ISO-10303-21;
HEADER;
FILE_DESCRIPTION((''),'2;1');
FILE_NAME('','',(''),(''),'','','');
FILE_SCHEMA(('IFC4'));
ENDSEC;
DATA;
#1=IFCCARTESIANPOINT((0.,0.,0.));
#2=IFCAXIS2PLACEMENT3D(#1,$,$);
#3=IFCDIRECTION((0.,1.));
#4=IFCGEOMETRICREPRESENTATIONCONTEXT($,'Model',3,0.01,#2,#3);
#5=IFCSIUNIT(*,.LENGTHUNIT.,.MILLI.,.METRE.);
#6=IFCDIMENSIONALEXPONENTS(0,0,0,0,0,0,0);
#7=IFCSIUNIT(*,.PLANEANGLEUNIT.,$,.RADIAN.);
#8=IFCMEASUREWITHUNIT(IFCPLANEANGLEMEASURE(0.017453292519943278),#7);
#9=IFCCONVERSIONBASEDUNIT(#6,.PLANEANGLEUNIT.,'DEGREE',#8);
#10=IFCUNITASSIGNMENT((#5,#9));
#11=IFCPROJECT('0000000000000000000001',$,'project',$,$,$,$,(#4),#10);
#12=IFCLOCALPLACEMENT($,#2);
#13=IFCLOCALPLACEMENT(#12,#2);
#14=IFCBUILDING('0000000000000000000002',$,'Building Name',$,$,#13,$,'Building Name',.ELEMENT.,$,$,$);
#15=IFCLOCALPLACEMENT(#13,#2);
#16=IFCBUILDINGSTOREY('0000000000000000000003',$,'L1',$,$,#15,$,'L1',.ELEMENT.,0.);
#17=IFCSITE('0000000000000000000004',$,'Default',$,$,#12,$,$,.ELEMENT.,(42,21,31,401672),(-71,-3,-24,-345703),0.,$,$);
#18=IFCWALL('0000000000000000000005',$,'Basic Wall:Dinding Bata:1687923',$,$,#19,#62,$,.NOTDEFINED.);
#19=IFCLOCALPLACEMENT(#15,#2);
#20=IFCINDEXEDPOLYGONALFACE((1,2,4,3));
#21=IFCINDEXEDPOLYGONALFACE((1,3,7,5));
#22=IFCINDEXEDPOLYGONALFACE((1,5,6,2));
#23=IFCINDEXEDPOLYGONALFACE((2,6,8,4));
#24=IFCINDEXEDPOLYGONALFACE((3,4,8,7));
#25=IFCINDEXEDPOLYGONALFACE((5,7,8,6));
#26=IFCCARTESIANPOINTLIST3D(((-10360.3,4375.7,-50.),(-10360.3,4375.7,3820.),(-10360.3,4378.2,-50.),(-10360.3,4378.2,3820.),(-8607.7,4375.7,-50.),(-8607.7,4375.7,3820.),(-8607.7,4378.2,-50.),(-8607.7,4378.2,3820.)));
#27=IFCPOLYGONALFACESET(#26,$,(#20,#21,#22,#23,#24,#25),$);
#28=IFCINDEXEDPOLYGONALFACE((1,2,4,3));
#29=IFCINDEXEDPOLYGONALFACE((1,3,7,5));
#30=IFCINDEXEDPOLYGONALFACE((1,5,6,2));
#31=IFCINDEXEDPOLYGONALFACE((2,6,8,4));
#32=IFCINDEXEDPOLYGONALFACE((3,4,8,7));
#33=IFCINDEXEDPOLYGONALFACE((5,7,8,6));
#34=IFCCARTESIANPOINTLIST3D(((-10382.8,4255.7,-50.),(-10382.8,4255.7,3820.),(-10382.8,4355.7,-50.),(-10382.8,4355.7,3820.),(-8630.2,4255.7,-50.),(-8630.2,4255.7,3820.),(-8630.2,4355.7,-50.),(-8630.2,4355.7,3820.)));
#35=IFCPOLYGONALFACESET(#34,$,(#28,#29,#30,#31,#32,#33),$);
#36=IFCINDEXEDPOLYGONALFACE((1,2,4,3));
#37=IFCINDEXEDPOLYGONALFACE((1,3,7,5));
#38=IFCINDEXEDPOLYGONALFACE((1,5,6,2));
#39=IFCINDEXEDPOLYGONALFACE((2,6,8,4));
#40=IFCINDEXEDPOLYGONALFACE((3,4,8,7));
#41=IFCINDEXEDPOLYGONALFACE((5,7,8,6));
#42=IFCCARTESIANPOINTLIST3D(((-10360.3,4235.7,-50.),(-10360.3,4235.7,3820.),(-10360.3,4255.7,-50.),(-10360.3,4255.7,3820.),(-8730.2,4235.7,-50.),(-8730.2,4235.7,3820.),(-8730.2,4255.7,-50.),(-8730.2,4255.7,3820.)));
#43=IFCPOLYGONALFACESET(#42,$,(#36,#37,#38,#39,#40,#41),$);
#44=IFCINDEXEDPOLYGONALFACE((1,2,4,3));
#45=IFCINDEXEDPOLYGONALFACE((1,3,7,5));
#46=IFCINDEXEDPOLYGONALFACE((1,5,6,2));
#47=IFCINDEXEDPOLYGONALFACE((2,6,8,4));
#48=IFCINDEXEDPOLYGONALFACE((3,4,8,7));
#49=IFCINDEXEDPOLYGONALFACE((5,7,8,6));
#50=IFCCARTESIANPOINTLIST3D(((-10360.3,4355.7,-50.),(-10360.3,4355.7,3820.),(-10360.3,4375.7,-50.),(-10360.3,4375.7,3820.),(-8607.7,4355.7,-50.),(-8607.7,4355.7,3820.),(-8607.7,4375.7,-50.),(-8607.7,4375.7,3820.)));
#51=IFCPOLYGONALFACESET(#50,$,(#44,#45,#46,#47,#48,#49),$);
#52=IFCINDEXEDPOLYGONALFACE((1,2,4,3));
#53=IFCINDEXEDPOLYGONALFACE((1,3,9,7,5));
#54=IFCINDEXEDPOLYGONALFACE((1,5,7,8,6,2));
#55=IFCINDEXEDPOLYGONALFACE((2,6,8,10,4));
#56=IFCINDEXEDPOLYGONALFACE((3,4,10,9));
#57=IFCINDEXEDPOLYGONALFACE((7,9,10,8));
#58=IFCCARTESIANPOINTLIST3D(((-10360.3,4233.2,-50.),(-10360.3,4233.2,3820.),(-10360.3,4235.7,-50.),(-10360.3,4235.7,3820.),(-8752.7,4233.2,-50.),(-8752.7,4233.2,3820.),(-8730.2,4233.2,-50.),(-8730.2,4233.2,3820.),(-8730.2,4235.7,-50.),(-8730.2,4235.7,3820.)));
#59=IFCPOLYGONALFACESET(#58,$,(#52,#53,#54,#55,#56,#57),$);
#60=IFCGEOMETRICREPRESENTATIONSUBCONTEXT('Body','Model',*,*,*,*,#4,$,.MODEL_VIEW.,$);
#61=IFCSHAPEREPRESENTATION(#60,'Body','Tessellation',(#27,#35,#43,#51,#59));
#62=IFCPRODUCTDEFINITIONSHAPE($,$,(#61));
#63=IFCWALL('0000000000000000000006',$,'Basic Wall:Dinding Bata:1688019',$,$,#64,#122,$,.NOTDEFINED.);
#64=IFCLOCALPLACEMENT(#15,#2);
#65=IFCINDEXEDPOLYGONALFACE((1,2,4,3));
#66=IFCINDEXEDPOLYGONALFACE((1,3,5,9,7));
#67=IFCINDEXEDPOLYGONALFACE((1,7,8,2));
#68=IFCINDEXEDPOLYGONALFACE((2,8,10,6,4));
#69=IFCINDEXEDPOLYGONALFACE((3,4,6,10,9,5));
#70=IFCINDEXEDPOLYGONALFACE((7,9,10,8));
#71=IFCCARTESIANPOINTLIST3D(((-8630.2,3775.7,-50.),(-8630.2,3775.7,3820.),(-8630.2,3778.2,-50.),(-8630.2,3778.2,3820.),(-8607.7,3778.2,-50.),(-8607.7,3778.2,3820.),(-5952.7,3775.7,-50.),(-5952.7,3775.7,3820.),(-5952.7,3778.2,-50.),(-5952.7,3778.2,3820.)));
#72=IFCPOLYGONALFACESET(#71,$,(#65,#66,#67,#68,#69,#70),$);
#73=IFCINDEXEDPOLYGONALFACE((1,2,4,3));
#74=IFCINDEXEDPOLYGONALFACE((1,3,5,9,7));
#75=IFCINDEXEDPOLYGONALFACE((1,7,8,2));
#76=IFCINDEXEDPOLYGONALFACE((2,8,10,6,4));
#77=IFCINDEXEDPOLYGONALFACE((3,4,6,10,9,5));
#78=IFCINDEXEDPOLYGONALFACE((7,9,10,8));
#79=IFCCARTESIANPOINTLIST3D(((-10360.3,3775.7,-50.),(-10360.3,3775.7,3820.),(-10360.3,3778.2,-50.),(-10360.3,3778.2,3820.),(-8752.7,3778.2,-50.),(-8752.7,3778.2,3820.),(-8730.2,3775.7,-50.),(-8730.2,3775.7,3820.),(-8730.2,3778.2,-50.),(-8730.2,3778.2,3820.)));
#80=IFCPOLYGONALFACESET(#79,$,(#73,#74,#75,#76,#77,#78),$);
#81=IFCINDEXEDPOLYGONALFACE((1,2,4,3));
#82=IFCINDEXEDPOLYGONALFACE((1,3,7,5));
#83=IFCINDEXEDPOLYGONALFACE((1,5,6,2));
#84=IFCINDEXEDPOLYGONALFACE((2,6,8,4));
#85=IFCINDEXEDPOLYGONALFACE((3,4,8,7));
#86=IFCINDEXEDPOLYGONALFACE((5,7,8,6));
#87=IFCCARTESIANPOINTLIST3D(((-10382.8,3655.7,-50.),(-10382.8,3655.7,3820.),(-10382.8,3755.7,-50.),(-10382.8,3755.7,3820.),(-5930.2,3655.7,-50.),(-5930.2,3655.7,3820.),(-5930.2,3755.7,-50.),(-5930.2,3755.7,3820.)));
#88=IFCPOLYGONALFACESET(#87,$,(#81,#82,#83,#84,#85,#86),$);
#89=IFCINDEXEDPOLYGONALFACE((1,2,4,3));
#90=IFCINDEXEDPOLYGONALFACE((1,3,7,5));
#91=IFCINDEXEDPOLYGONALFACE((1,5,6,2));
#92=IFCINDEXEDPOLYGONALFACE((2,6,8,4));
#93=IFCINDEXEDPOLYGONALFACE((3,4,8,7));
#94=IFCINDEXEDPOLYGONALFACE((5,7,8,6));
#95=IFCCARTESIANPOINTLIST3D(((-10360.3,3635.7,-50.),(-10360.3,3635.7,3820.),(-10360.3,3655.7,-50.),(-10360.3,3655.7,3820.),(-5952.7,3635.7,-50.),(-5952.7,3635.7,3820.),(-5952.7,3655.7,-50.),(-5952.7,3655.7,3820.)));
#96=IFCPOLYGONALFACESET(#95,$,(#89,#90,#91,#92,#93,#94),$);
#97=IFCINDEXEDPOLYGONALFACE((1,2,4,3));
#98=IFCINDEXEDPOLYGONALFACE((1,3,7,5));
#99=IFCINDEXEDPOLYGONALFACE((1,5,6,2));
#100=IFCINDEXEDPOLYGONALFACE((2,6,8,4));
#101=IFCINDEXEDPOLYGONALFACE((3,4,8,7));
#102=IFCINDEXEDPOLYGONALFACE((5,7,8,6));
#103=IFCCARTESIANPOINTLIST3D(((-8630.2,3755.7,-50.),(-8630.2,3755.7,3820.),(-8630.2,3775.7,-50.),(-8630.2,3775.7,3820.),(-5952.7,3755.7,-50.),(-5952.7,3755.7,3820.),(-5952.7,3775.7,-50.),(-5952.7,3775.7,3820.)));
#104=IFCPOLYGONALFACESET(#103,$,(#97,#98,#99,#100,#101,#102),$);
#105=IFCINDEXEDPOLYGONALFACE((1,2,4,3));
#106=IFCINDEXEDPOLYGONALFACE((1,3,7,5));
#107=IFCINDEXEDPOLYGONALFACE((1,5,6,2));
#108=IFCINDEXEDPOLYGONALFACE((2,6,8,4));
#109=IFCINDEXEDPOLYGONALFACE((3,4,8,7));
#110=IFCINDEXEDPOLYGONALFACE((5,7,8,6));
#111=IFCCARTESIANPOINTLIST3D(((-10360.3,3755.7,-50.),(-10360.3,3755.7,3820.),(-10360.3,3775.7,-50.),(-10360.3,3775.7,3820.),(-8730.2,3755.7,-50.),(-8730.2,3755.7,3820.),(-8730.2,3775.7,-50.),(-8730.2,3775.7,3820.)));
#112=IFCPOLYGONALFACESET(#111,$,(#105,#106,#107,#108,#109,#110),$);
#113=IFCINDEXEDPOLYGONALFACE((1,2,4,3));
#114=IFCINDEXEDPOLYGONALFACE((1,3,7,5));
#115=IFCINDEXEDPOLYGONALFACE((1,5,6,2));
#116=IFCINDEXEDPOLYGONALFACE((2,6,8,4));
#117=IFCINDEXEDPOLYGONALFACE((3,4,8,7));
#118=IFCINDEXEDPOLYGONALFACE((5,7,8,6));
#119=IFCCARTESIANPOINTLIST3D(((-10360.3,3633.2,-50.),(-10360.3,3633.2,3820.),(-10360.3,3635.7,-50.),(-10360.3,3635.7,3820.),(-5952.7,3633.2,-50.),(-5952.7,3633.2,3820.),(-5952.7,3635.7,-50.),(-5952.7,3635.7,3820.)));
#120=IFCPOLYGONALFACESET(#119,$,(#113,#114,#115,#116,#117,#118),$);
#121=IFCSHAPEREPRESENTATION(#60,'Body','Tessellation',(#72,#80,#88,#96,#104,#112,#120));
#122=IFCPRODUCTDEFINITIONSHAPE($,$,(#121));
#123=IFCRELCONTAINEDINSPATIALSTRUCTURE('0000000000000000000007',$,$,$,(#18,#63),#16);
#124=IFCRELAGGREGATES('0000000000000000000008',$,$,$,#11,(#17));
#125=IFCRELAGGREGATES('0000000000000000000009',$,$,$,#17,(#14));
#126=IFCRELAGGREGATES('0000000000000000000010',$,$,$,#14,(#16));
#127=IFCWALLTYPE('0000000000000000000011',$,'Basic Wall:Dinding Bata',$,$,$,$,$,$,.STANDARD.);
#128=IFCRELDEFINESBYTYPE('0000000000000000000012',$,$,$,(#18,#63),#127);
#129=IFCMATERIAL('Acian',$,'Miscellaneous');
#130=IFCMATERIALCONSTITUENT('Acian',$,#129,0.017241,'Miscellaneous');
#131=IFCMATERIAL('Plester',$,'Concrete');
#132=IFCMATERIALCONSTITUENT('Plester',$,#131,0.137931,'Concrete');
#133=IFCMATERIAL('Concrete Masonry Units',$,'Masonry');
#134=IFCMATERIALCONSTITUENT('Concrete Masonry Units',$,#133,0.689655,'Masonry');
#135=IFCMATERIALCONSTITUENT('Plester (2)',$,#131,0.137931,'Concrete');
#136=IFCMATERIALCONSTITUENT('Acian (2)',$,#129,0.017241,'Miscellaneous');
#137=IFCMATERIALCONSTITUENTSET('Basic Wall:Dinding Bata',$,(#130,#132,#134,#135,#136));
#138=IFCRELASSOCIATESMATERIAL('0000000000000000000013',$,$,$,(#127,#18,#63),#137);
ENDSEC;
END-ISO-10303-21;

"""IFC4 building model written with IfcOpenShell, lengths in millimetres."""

from ifc_helpers import new_model, entity, si_unit, converted_unit, direction, frame, origin, place, context, subcontext, project, spatial, indexed_curve, outline, extrude, material, constituent, constituent_set, type_object, element, save


model = new_model("IFC4")

# Units and contexts
model_context = context("Model", 3, precision=0.01, world=origin(), true_north=direction((0.0, 1.0)))
body_context = subcontext(model_context, "Body", "Model", "MODEL_VIEW")
ifc_project = project(units=[si_unit("LENGTHUNIT", "METRE", prefix="MILLI"), converted_unit("PLANEANGLEUNIT", "DEGREE", entity("IfcPlaneAngleMeasure", 0.017453292519943278), si_unit("PLANEANGLEUNIT", "RADIAN"), dimensions=[0, 0, 0, 0, 0, 0, 0])], contexts=[model_context])

# Site, building, storey
site_placement = place(None, origin())
site = spatial("IfcSite", under=ifc_project, at=site_placement, Name="Default", CompositionType="ELEMENT", RefLatitude=(42, 21, 31, 401672), RefLongitude=(-71, -3, -24, -345703), RefElevation=0.0)
building_placement = place(site_placement, origin())
building = spatial("IfcBuilding", under=site, at=building_placement, Name="Building Name", LongName="Building Name", CompositionType="ELEMENT")
storey_placement = place(building_placement, origin())
storey = spatial("IfcBuildingStorey", under=building, at=storey_placement, Name="L1", LongName="L1", CompositionType="ELEMENT", Elevation=0.0)

# Walls
ifc_material_1 = material(Name="Acian", Category="Miscellaneous")
ifc_constituent_1 = constituent(ifc_material_1, Name="Acian", Category="Miscellaneous", fraction=0.017241)
ifc_material_2 = material(Name="Plester", Category="Concrete")
ifc_constituent_2 = constituent(ifc_material_2, Name="Plester", Category="Concrete", fraction=0.137931)
ifc_material_3 = material(Name="Concrete Masonry Units", Category="Masonry")
ifc_constituent_3 = constituent(ifc_material_3, Name="Concrete Masonry Units", Category="Masonry", fraction=0.689655)
ifc_constituent_4 = constituent(ifc_material_2, Name="Plester (2)", Category="Concrete", fraction=0.137931)
ifc_constituent_5 = constituent(ifc_material_1, Name="Acian (2)", Category="Miscellaneous", fraction=0.017241)
ifc_constituent_set = constituent_set(constituents=[ifc_constituent_1, ifc_constituent_2, ifc_constituent_3, ifc_constituent_4, ifc_constituent_5], Name="Basic Wall:Dinding Bata")
wall_type = type_object("IfcWallType", Name="Basic Wall:Dinding Bata", PredefinedType="STANDARD", material=ifc_constituent_set)
wall_1_placement = place(storey_placement, frame((-10360.3, 4305.7, -50.0)))
element("IfcWall", 1, at=wall_1_placement, inside=storey, type_object=wall_type, material=ifc_constituent_set, Name="Basic Wall:Dinding Bata:1687923", PredefinedType="NOTDEFINED", context=body_context, shape_type="SweptSolid", body=[
    extrude(outline(indexed_curve([(-1.3, -876.3), (1.2, -876.3), (1.3, 876.3), (-1.2, 876.3), (-1.3, -876.3)], self_intersect=False)), frame((876.3, 71.2, 0.0), z_axis=(0.0, 0.0, 1.0), x_axis=(0.0, -1.0, 0.0)), (0.0, 0.0, 1.0), 3870.0),
    extrude(outline(indexed_curve([(-876.3, -50.0), (876.3, -50.0), (876.3, 50.0), (-876.3, 50.0), (-876.3, -50.0)], self_intersect=False)), frame((853.8, 0.0, 0.0)), (0.0, 0.0, 1.0), 3870.0),
    extrude(outline(indexed_curve([(-815.0, -10.0), (815.0, -10.0), (815.0, 10.0), (-815.0, 10.0), (-815.0, -10.0)], self_intersect=False)), frame((815.0, -60.0, 0.0)), (0.0, 0.0, 1.0), 3870.0),
    extrude(outline(indexed_curve([(-876.3, -10.0), (876.3, -10.0), (876.3, 10.0), (-876.3, 10.0), (-876.3, -10.0)], self_intersect=False)), frame((876.3, 60.0, 0.0)), (0.0, 0.0, 1.0), 3870.0),
    extrude(outline(indexed_curve([(634.0, -1.0), (656.5, -1.0), (656.5, 1.5), (-973.5, 1.5), (-973.5, -1.0), (634.0, -1.0)], self_intersect=False)), frame((973.5, -71.5, 0.0)), (0.0, 0.0, 1.0), 3870.0),
])
wall_2_placement = place(storey_placement, frame((-10360.3, 3705.7, -50.0)))
element("IfcWall", 2, at=wall_2_placement, inside=storey, type_object=wall_type, material=ifc_constituent_set, Name="Basic Wall:Dinding Bata:1688019", PredefinedType="NOTDEFINED", context=body_context, shape_type="SweptSolid", body=[
    extrude(outline(indexed_curve([(1053.0, -1.0), (1075.5, -1.0), (1075.5, 1.5), (-1602.0, 1.5), (-1602.0, -1.0), (1053.0, -1.0)], self_intersect=False)), frame((2805.6, 71.5, 0.0), z_axis=(0.0, 0.0, 1.0), x_axis=(-1.0, 0.0, 0.0)), (0.0, 0.0, 1.0), 3870.0),
    extrude(outline(indexed_curve([(-973.5, -1.5), (656.5, -1.5), (656.5, 1.0), (634.0, 1.0), (-973.5, 1.0), (-973.5, -1.5)], self_intersect=False)), frame((973.5, 71.5, 0.0)), (0.0, 0.0, 1.0), 3870.0),
    extrude(outline(indexed_curve([(-2226.3, -50.0), (2226.3, -50.0), (2226.3, 50.0), (-2226.3, 50.0), (-2226.3, -50.0)], self_intersect=False)), frame((2203.8, 0.0, 0.0)), (0.0, 0.0, 1.0), 3870.0),
    extrude(outline(indexed_curve([(-2203.8, -10.0), (2203.8, -10.0), (2203.8, 10.0), (-2203.8, 10.0), (-2203.8, -10.0)], self_intersect=False)), frame((2203.8, -60.0, 0.0)), (0.0, 0.0, 1.0), 3870.0),
    extrude(outline(indexed_curve([(-1338.7, -10.0), (1338.7, -10.0), (1338.7, 10.0), (-1338.7, 10.0), (-1338.7, -10.0)], self_intersect=False)), frame((3068.8, 60.0, 0.0), z_axis=(0.0, 0.0, 1.0), x_axis=(-1.0, 0.0, 0.0)), (0.0, 0.0, 1.0), 3870.0),
    extrude(outline(indexed_curve([(-815.0, -10.0), (815.0, -10.0), (815.0, 10.0), (-815.0, 10.0), (-815.0, -10.0)], self_intersect=False)), frame((815.0, 60.0, 0.0)), (0.0, 0.0, 1.0), 3870.0),
    extrude(outline(indexed_curve([(-1.3, -2203.8), (1.2, -2203.8), (1.3, 2203.8), (-1.2, 2203.8), (-1.3, -2203.8)], self_intersect=False)), frame((2203.8, -71.3, 0.0), z_axis=(0.0, 0.0, 1.0), x_axis=(0.0, 1.0, 0.0)), (0.0, 0.0, 1.0), 3870.0),
])

save(model, "model.ifc")
